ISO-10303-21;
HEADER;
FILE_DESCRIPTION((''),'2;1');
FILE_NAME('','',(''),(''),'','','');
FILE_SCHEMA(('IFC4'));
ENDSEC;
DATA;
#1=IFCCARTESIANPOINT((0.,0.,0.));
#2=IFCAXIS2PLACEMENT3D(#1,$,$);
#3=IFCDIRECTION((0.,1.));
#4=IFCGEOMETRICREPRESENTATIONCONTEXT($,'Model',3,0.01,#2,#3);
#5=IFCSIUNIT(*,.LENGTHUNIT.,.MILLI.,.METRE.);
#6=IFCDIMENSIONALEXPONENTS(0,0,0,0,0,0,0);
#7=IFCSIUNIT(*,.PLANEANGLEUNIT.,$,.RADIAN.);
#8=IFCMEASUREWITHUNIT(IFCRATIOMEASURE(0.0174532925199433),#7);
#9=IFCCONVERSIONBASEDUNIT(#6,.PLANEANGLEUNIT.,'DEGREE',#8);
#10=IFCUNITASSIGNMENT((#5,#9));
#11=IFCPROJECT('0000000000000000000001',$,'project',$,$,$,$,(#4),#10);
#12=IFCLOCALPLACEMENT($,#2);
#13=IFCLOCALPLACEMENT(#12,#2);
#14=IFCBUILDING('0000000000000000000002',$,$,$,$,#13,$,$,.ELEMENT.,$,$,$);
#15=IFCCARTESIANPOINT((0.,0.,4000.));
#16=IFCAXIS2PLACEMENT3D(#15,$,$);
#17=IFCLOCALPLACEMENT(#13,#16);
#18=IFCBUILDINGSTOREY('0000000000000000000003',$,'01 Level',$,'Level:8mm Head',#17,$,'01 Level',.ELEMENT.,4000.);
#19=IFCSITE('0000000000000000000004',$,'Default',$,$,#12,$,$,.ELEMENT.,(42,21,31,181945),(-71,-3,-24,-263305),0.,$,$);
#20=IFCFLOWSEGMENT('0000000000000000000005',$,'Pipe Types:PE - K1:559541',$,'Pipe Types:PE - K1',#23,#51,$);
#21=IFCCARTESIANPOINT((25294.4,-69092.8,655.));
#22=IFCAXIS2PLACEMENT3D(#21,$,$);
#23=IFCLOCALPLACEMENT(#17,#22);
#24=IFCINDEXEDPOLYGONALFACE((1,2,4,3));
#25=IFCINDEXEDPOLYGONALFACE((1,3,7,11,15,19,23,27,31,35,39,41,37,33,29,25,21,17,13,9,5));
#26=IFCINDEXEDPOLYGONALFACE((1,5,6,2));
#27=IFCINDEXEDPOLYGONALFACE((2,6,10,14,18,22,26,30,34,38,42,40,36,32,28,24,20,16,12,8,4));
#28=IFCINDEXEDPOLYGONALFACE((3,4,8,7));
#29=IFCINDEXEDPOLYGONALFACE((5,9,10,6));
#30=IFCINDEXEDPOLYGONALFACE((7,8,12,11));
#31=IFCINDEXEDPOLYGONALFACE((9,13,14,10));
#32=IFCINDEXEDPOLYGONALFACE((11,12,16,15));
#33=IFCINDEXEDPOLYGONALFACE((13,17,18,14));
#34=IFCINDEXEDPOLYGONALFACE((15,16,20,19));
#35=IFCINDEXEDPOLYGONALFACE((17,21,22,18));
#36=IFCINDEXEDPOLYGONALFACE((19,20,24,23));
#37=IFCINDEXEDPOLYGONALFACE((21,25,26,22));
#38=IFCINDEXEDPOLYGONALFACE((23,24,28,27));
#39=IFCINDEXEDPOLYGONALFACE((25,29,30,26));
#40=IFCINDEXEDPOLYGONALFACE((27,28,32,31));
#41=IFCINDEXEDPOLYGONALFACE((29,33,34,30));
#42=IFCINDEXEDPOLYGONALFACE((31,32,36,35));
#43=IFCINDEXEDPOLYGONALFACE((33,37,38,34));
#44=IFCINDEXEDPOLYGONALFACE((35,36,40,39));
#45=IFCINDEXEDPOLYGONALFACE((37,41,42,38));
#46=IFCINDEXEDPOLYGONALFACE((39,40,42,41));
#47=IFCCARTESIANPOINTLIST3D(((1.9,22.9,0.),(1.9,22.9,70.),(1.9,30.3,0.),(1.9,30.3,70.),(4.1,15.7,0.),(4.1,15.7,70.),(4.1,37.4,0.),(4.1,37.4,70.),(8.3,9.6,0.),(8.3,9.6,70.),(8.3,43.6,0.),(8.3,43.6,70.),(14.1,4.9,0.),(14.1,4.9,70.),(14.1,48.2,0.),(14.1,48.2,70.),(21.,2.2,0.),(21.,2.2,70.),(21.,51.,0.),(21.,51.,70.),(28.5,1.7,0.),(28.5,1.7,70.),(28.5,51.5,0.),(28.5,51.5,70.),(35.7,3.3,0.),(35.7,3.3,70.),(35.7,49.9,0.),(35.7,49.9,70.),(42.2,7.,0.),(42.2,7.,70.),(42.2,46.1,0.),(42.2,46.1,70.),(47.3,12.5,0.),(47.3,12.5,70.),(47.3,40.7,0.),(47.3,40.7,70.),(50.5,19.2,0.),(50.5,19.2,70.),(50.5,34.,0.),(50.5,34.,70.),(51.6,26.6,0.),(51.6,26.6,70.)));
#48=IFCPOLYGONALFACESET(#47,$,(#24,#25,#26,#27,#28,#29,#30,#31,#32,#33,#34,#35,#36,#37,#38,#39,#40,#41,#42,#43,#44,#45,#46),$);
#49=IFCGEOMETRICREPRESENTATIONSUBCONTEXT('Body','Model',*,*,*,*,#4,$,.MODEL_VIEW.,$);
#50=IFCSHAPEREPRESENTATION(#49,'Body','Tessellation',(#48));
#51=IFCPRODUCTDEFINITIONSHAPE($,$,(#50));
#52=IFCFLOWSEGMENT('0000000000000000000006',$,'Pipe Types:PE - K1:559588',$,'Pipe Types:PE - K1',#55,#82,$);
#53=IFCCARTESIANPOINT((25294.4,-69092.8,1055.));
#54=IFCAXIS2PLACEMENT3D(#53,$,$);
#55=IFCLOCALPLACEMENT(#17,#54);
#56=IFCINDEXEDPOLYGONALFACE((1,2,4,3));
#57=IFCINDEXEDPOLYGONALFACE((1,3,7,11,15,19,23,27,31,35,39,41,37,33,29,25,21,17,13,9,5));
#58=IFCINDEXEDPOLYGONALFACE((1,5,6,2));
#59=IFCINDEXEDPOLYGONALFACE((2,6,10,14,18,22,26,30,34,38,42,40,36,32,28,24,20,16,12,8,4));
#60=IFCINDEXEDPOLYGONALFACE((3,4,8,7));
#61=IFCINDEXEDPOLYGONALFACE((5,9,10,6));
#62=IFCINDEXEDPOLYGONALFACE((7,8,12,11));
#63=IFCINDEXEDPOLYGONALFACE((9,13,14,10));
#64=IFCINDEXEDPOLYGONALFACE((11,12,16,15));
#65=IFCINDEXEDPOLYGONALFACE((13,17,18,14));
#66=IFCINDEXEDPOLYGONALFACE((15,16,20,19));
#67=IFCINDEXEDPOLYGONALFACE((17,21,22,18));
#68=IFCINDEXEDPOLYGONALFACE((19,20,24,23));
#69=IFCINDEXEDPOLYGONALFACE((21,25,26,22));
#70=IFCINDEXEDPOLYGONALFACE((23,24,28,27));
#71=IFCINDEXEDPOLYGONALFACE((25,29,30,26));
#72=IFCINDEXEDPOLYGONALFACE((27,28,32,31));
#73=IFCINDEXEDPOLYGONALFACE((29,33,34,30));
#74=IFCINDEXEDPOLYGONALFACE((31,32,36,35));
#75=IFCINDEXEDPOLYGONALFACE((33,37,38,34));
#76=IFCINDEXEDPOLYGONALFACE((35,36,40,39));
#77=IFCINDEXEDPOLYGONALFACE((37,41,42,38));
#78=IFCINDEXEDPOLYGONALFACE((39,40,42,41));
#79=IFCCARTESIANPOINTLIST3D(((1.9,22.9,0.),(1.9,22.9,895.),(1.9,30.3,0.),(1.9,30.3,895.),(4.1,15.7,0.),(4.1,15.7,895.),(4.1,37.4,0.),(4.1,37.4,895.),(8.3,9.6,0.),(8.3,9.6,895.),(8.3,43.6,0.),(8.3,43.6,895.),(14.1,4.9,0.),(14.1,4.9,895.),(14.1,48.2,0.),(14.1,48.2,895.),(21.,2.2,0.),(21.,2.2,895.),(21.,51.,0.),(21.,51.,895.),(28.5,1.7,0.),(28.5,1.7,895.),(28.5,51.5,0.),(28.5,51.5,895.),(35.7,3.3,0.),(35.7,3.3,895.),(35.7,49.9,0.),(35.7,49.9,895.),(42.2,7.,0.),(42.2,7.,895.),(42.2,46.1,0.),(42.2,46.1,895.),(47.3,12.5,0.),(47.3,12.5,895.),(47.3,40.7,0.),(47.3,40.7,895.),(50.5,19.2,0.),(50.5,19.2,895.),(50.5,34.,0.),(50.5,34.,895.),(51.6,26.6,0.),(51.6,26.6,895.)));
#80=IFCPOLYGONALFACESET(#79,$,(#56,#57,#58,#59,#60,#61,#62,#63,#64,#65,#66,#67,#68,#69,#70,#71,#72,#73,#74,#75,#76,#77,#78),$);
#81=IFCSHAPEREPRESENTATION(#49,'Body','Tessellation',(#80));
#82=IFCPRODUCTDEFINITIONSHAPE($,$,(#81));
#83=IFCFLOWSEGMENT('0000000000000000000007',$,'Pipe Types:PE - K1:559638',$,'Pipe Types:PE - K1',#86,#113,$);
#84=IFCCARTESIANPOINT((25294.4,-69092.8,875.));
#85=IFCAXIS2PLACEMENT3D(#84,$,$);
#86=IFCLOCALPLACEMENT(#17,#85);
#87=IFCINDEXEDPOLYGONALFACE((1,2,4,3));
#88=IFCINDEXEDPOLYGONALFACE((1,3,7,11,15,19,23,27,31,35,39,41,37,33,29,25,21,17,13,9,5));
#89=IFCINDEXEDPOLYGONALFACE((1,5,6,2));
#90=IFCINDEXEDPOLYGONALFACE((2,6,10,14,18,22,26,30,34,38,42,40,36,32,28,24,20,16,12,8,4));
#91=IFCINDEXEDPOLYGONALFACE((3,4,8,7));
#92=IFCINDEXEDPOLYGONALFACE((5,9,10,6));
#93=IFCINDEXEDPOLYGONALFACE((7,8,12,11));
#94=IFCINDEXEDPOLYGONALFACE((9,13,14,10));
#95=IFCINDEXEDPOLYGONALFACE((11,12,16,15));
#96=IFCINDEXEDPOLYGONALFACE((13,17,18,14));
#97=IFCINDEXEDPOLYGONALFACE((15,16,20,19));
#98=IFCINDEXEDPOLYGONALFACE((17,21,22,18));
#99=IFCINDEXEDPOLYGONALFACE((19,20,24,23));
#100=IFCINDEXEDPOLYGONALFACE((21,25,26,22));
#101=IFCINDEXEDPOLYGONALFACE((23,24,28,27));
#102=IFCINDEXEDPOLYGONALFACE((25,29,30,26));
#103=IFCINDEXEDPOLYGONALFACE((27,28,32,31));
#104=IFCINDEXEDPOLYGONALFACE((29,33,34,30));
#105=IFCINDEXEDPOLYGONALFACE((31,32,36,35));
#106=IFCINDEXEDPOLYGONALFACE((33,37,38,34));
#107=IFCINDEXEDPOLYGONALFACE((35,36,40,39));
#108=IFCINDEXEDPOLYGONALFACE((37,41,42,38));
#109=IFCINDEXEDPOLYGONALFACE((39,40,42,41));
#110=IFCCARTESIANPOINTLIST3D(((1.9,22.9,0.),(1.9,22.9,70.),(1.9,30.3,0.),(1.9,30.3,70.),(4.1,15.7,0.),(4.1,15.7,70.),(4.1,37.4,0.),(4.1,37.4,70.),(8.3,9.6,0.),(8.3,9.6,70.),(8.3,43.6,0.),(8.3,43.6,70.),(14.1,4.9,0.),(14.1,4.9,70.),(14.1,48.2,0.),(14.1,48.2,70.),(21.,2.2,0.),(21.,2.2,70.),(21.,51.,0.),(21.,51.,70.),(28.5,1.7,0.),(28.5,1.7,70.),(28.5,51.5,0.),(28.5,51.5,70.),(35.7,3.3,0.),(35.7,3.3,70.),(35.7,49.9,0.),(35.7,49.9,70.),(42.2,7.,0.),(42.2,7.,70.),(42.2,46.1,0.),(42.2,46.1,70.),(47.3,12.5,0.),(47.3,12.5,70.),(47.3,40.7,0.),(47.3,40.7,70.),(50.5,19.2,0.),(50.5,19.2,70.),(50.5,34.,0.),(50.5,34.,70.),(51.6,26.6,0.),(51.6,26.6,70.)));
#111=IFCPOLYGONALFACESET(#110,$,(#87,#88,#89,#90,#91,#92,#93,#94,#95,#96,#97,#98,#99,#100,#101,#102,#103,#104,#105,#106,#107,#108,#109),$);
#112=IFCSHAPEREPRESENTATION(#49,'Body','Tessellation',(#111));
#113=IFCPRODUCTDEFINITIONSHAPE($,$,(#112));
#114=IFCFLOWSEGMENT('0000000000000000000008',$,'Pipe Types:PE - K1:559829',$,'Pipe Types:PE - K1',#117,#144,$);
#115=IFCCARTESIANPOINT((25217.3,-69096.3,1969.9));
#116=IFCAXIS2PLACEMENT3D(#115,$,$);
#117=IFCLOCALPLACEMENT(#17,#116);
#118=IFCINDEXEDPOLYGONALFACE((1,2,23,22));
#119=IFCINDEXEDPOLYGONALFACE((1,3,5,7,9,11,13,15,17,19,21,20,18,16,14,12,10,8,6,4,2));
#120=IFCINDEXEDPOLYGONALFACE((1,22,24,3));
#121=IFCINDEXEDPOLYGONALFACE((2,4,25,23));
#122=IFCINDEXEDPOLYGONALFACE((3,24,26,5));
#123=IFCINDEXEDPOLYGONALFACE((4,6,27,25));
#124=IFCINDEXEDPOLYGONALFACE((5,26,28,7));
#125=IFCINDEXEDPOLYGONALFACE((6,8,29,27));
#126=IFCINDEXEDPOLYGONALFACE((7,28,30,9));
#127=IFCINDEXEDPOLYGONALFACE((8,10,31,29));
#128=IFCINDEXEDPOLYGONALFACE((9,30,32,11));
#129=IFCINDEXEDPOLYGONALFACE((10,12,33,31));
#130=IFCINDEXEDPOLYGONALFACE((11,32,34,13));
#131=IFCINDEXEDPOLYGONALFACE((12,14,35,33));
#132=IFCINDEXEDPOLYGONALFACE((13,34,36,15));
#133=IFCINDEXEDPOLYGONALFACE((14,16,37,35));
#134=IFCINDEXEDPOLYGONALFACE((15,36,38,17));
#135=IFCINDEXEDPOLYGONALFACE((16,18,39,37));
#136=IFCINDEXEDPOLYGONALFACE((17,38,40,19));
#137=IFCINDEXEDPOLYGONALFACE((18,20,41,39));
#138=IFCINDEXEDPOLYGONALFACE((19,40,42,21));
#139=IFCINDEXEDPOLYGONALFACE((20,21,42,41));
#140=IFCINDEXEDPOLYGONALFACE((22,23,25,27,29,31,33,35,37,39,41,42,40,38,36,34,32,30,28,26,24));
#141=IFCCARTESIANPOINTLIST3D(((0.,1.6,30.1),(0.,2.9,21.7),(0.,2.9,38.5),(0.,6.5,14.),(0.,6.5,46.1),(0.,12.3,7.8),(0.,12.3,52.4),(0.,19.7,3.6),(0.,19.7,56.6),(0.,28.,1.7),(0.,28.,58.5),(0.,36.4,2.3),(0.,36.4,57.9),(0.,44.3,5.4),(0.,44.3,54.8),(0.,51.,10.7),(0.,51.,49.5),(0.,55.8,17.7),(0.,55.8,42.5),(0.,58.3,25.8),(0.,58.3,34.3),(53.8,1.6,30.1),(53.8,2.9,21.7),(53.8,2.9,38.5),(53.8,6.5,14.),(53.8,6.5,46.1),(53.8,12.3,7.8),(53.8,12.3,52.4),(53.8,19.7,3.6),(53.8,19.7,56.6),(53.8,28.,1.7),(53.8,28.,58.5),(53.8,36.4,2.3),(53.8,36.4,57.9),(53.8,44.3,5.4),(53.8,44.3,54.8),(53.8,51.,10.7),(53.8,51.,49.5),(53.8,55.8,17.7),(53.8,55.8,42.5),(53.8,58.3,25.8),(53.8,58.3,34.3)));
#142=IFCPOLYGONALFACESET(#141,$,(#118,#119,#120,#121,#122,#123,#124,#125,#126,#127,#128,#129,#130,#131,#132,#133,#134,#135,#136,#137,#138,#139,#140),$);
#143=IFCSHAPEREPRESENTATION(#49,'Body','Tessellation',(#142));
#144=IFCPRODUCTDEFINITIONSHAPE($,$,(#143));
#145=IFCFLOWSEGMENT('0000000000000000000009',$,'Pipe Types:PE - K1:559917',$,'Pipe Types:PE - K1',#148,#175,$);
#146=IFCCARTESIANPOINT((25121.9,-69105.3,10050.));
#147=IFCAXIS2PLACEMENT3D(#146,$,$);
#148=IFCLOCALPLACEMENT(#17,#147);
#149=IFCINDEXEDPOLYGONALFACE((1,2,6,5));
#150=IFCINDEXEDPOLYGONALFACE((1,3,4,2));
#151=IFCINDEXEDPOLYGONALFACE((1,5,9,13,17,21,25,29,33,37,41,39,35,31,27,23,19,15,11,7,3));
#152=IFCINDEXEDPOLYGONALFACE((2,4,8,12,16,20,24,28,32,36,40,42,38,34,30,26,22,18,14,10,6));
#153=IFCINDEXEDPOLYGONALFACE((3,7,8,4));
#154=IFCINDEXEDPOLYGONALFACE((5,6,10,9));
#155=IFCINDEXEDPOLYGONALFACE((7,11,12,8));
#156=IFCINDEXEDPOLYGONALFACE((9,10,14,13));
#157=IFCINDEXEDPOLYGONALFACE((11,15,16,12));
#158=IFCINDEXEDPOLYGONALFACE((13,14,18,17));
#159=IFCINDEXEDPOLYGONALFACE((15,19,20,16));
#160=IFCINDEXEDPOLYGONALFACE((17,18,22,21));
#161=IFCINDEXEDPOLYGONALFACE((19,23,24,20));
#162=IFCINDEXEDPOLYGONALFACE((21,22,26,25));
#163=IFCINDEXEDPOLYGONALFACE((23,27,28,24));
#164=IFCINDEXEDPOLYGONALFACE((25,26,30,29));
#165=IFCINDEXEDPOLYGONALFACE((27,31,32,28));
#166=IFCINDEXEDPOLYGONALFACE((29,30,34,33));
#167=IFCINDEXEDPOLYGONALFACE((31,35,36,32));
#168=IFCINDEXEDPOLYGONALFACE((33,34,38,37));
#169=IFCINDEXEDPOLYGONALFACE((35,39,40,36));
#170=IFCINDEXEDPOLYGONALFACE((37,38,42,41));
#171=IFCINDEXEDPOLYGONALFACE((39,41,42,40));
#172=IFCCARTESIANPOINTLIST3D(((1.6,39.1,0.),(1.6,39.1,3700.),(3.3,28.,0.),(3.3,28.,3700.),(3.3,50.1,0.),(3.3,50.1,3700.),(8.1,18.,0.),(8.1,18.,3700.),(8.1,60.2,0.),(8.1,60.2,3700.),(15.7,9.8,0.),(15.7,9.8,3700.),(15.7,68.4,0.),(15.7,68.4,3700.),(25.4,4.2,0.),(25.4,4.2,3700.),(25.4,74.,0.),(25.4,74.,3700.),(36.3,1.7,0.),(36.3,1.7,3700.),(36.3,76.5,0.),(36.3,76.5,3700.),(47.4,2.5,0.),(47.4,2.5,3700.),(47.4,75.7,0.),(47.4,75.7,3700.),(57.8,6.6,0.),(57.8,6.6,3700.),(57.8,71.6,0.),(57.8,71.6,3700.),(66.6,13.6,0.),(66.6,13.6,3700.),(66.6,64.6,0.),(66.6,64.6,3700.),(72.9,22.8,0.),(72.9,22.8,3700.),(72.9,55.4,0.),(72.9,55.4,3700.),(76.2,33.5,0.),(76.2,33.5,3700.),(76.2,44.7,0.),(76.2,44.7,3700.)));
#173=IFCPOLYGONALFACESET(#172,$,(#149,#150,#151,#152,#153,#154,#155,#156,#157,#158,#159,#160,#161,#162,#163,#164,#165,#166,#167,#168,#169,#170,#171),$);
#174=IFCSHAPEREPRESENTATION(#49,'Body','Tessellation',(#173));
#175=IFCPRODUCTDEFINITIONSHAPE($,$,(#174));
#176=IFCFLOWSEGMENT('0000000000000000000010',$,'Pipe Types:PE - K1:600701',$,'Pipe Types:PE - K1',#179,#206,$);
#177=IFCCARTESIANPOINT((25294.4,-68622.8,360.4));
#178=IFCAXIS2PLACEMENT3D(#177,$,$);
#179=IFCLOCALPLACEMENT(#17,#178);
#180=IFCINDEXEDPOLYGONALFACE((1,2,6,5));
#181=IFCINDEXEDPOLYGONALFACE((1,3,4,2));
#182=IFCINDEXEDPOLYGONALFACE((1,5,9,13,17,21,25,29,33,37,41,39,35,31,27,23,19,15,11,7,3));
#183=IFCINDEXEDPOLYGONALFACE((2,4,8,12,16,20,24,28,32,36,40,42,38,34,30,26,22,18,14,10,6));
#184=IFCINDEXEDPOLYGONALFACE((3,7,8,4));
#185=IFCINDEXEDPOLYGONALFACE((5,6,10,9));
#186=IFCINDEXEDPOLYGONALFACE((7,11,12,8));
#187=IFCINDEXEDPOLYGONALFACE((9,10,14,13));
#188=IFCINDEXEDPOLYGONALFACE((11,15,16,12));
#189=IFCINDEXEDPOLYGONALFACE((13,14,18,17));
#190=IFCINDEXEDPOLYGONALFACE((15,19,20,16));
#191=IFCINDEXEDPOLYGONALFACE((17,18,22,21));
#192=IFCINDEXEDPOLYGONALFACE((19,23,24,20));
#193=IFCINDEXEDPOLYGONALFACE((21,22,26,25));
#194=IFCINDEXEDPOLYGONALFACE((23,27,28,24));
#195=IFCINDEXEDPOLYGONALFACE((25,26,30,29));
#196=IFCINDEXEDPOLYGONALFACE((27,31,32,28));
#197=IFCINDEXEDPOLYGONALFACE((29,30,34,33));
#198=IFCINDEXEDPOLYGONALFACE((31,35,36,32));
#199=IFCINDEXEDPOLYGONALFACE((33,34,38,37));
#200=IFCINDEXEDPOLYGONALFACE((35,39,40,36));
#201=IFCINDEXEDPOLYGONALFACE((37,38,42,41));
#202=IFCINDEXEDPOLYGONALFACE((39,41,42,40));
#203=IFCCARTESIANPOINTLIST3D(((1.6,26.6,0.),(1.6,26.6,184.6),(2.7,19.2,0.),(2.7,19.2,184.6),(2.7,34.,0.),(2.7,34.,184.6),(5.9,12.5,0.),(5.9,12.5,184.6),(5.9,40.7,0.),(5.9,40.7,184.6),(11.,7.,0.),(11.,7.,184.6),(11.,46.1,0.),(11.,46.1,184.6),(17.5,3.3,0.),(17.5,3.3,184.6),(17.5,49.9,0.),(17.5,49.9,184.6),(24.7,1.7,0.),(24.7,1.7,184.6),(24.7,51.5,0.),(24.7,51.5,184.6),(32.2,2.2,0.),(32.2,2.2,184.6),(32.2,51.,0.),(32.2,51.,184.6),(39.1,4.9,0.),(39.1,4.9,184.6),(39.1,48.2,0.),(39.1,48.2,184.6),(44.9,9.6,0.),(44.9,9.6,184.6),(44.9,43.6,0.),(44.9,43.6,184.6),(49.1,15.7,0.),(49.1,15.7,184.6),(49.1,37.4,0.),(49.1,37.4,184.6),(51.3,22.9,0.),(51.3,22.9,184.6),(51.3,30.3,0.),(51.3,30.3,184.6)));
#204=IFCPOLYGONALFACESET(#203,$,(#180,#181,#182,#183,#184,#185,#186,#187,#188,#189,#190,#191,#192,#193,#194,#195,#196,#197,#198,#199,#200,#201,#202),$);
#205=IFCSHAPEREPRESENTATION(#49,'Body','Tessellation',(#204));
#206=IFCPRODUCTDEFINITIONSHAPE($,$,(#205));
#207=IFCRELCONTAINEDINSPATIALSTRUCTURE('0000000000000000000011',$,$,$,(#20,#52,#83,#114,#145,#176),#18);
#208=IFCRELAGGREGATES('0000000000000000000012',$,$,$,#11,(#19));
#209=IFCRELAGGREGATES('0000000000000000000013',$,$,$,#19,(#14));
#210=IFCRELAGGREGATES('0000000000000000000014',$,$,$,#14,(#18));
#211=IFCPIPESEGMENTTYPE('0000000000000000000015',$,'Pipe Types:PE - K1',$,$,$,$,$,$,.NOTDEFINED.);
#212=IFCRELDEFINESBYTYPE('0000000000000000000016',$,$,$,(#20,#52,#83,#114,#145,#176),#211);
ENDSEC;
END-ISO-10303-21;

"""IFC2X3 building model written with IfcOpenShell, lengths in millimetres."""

from ifc_helpers import new_model, entity, si_unit, converted_unit, direction, frame, frame_2d, origin, origin_2d_with_axis, place, context, subcontext, project, spatial, circle, extrude, type_object, element, save


model = new_model("IFC2X3")

# Units and contexts
model_context = context("Model", 3, precision=0.01, world=origin(), true_north=direction((0.0, 1.0)))
body_context = subcontext(model_context, "Body", "Model", "MODEL_VIEW")
ifc_project = project(units=[si_unit("LENGTHUNIT", "METRE", prefix="MILLI"), converted_unit("PLANEANGLEUNIT", "DEGREE", entity("IfcRatioMeasure", 0.0174532925199433), si_unit("PLANEANGLEUNIT", "RADIAN"), dimensions=[0, 0, 0, 0, 0, 0, 0])], contexts=[model_context])

# Site, building, storey
site_placement = place(None, origin())
site = spatial("IfcSite", under=ifc_project, at=site_placement, Name="Default", CompositionType="ELEMENT", RefLatitude=(42, 21, 31, 181945), RefLongitude=(-71, -3, -24, -263305), RefElevation=0.0)
building_placement = place(site_placement, origin())
building = spatial("IfcBuilding", under=site, at=building_placement, CompositionType="ELEMENT")
storey_placement = place(building_placement, frame((0.0, 0.0, 4000.0)))
storey = spatial("IfcBuildingStorey", under=building, at=storey_placement, Name="01 Level", ObjectType="Level:8mm Head", LongName="01 Level", CompositionType="ELEMENT", Elevation=4000.0)

# Flow segments
pipe_segment_type_1 = type_object("IfcPipeSegmentType", Name="Pipe Types:PE - K1", PredefinedType="NOTDEFINED")
flow_segment_1_placement = place(storey_placement, frame((25294.4, -69092.8, 655.0)))
element("IfcFlowSegment", 1, at=flow_segment_1_placement, inside=storey, type_object=pipe_segment_type_1, Name="Pipe Types:PE - K1:559541", ObjectType="Pipe Types:PE - K1", context=body_context, shape_type="SweptSolid", body=[
    extrude(circle(Radius=25.0, at=frame_2d((0.0, 0.0), x_axis=(1.0, 0.0))), frame((26.6, 26.6, 0.0)), (0.0, 0.0, 1.0), 70.0),
])
flow_segment_2_placement = place(storey_placement, frame((25294.4, -69092.8, 1055.0)))
element("IfcFlowSegment", 2, at=flow_segment_2_placement, inside=storey, type_object=pipe_segment_type_1, Name="Pipe Types:PE - K1:559588", ObjectType="Pipe Types:PE - K1", context=body_context, shape_type="SweptSolid", body=[
    extrude(circle(Radius=25.0, at=frame_2d((0.0, 0.0), x_axis=(1.0, 0.0))), frame((26.6, 26.6, 0.0)), (0.0, 0.0, 1.0), 895.0),
])
flow_segment_3_placement = place(storey_placement, frame((25294.4, -69092.8, 875.0)))
element("IfcFlowSegment", 3, at=flow_segment_3_placement, inside=storey, type_object=pipe_segment_type_1, Name="Pipe Types:PE - K1:559638", ObjectType="Pipe Types:PE - K1", context=body_context, shape_type="SweptSolid", body=[
    extrude(circle(Radius=25.0, at=origin_2d_with_axis()), frame((26.6, 26.6, 0.0)), (0.0, 0.0, 1.0), 70.0),
])
flow_segment_4_placement = place(storey_placement, frame((25217.3, -69096.3, 1969.9)))
element("IfcFlowSegment", 4, at=flow_segment_4_placement, inside=storey, type_object=pipe_segment_type_1, Name="Pipe Types:PE - K1:559829", ObjectType="Pipe Types:PE - K1", context=body_context, shape_type="SweptSolid", body=[
    extrude(circle(Radius=28.5, at=origin_2d_with_axis()), frame((0.0, 30.1, 30.1), z_axis=(1.0, 0.0, 0.0), x_axis=(0.0, -1.0, 0.0)), (0.0, 0.0, 1.0), 53.8),
])
flow_segment_5_placement = place(storey_placement, frame((25121.9, -69105.3, 10050.0)))
element("IfcFlowSegment", 5, at=flow_segment_5_placement, inside=storey, type_object=pipe_segment_type_1, Name="Pipe Types:PE - K1:559917", ObjectType="Pipe Types:PE - K1", context=body_context, shape_type="SweptSolid", body=[
    extrude(circle(Radius=37.5, at=origin_2d_with_axis()), frame((39.1, 39.1, 0.0), z_axis=(0.0, 0.0, 1.0), x_axis=(-1.0, 0.0, 0.0)), (0.0, 0.0, 1.0), 3700.0),
])
flow_segment_6_placement = place(storey_placement, frame((25294.4, -68622.8, 360.4)))
element("IfcFlowSegment", 6, at=flow_segment_6_placement, inside=storey, type_object=pipe_segment_type_1, Name="Pipe Types:PE - K1:600701", ObjectType="Pipe Types:PE - K1", context=body_context, shape_type="SweptSolid", body=[
    extrude(circle(Radius=25.0, at=frame_2d((0.0, 0.0), x_axis=(1.0, 0.0))), frame((26.6, 26.6, 0.0), z_axis=(0.0, 0.0, 1.0), x_axis=(-1.0, 0.0, 0.0)), (0.0, 0.0, 1.0), 184.6),
])

save(model, "model.ifc")
